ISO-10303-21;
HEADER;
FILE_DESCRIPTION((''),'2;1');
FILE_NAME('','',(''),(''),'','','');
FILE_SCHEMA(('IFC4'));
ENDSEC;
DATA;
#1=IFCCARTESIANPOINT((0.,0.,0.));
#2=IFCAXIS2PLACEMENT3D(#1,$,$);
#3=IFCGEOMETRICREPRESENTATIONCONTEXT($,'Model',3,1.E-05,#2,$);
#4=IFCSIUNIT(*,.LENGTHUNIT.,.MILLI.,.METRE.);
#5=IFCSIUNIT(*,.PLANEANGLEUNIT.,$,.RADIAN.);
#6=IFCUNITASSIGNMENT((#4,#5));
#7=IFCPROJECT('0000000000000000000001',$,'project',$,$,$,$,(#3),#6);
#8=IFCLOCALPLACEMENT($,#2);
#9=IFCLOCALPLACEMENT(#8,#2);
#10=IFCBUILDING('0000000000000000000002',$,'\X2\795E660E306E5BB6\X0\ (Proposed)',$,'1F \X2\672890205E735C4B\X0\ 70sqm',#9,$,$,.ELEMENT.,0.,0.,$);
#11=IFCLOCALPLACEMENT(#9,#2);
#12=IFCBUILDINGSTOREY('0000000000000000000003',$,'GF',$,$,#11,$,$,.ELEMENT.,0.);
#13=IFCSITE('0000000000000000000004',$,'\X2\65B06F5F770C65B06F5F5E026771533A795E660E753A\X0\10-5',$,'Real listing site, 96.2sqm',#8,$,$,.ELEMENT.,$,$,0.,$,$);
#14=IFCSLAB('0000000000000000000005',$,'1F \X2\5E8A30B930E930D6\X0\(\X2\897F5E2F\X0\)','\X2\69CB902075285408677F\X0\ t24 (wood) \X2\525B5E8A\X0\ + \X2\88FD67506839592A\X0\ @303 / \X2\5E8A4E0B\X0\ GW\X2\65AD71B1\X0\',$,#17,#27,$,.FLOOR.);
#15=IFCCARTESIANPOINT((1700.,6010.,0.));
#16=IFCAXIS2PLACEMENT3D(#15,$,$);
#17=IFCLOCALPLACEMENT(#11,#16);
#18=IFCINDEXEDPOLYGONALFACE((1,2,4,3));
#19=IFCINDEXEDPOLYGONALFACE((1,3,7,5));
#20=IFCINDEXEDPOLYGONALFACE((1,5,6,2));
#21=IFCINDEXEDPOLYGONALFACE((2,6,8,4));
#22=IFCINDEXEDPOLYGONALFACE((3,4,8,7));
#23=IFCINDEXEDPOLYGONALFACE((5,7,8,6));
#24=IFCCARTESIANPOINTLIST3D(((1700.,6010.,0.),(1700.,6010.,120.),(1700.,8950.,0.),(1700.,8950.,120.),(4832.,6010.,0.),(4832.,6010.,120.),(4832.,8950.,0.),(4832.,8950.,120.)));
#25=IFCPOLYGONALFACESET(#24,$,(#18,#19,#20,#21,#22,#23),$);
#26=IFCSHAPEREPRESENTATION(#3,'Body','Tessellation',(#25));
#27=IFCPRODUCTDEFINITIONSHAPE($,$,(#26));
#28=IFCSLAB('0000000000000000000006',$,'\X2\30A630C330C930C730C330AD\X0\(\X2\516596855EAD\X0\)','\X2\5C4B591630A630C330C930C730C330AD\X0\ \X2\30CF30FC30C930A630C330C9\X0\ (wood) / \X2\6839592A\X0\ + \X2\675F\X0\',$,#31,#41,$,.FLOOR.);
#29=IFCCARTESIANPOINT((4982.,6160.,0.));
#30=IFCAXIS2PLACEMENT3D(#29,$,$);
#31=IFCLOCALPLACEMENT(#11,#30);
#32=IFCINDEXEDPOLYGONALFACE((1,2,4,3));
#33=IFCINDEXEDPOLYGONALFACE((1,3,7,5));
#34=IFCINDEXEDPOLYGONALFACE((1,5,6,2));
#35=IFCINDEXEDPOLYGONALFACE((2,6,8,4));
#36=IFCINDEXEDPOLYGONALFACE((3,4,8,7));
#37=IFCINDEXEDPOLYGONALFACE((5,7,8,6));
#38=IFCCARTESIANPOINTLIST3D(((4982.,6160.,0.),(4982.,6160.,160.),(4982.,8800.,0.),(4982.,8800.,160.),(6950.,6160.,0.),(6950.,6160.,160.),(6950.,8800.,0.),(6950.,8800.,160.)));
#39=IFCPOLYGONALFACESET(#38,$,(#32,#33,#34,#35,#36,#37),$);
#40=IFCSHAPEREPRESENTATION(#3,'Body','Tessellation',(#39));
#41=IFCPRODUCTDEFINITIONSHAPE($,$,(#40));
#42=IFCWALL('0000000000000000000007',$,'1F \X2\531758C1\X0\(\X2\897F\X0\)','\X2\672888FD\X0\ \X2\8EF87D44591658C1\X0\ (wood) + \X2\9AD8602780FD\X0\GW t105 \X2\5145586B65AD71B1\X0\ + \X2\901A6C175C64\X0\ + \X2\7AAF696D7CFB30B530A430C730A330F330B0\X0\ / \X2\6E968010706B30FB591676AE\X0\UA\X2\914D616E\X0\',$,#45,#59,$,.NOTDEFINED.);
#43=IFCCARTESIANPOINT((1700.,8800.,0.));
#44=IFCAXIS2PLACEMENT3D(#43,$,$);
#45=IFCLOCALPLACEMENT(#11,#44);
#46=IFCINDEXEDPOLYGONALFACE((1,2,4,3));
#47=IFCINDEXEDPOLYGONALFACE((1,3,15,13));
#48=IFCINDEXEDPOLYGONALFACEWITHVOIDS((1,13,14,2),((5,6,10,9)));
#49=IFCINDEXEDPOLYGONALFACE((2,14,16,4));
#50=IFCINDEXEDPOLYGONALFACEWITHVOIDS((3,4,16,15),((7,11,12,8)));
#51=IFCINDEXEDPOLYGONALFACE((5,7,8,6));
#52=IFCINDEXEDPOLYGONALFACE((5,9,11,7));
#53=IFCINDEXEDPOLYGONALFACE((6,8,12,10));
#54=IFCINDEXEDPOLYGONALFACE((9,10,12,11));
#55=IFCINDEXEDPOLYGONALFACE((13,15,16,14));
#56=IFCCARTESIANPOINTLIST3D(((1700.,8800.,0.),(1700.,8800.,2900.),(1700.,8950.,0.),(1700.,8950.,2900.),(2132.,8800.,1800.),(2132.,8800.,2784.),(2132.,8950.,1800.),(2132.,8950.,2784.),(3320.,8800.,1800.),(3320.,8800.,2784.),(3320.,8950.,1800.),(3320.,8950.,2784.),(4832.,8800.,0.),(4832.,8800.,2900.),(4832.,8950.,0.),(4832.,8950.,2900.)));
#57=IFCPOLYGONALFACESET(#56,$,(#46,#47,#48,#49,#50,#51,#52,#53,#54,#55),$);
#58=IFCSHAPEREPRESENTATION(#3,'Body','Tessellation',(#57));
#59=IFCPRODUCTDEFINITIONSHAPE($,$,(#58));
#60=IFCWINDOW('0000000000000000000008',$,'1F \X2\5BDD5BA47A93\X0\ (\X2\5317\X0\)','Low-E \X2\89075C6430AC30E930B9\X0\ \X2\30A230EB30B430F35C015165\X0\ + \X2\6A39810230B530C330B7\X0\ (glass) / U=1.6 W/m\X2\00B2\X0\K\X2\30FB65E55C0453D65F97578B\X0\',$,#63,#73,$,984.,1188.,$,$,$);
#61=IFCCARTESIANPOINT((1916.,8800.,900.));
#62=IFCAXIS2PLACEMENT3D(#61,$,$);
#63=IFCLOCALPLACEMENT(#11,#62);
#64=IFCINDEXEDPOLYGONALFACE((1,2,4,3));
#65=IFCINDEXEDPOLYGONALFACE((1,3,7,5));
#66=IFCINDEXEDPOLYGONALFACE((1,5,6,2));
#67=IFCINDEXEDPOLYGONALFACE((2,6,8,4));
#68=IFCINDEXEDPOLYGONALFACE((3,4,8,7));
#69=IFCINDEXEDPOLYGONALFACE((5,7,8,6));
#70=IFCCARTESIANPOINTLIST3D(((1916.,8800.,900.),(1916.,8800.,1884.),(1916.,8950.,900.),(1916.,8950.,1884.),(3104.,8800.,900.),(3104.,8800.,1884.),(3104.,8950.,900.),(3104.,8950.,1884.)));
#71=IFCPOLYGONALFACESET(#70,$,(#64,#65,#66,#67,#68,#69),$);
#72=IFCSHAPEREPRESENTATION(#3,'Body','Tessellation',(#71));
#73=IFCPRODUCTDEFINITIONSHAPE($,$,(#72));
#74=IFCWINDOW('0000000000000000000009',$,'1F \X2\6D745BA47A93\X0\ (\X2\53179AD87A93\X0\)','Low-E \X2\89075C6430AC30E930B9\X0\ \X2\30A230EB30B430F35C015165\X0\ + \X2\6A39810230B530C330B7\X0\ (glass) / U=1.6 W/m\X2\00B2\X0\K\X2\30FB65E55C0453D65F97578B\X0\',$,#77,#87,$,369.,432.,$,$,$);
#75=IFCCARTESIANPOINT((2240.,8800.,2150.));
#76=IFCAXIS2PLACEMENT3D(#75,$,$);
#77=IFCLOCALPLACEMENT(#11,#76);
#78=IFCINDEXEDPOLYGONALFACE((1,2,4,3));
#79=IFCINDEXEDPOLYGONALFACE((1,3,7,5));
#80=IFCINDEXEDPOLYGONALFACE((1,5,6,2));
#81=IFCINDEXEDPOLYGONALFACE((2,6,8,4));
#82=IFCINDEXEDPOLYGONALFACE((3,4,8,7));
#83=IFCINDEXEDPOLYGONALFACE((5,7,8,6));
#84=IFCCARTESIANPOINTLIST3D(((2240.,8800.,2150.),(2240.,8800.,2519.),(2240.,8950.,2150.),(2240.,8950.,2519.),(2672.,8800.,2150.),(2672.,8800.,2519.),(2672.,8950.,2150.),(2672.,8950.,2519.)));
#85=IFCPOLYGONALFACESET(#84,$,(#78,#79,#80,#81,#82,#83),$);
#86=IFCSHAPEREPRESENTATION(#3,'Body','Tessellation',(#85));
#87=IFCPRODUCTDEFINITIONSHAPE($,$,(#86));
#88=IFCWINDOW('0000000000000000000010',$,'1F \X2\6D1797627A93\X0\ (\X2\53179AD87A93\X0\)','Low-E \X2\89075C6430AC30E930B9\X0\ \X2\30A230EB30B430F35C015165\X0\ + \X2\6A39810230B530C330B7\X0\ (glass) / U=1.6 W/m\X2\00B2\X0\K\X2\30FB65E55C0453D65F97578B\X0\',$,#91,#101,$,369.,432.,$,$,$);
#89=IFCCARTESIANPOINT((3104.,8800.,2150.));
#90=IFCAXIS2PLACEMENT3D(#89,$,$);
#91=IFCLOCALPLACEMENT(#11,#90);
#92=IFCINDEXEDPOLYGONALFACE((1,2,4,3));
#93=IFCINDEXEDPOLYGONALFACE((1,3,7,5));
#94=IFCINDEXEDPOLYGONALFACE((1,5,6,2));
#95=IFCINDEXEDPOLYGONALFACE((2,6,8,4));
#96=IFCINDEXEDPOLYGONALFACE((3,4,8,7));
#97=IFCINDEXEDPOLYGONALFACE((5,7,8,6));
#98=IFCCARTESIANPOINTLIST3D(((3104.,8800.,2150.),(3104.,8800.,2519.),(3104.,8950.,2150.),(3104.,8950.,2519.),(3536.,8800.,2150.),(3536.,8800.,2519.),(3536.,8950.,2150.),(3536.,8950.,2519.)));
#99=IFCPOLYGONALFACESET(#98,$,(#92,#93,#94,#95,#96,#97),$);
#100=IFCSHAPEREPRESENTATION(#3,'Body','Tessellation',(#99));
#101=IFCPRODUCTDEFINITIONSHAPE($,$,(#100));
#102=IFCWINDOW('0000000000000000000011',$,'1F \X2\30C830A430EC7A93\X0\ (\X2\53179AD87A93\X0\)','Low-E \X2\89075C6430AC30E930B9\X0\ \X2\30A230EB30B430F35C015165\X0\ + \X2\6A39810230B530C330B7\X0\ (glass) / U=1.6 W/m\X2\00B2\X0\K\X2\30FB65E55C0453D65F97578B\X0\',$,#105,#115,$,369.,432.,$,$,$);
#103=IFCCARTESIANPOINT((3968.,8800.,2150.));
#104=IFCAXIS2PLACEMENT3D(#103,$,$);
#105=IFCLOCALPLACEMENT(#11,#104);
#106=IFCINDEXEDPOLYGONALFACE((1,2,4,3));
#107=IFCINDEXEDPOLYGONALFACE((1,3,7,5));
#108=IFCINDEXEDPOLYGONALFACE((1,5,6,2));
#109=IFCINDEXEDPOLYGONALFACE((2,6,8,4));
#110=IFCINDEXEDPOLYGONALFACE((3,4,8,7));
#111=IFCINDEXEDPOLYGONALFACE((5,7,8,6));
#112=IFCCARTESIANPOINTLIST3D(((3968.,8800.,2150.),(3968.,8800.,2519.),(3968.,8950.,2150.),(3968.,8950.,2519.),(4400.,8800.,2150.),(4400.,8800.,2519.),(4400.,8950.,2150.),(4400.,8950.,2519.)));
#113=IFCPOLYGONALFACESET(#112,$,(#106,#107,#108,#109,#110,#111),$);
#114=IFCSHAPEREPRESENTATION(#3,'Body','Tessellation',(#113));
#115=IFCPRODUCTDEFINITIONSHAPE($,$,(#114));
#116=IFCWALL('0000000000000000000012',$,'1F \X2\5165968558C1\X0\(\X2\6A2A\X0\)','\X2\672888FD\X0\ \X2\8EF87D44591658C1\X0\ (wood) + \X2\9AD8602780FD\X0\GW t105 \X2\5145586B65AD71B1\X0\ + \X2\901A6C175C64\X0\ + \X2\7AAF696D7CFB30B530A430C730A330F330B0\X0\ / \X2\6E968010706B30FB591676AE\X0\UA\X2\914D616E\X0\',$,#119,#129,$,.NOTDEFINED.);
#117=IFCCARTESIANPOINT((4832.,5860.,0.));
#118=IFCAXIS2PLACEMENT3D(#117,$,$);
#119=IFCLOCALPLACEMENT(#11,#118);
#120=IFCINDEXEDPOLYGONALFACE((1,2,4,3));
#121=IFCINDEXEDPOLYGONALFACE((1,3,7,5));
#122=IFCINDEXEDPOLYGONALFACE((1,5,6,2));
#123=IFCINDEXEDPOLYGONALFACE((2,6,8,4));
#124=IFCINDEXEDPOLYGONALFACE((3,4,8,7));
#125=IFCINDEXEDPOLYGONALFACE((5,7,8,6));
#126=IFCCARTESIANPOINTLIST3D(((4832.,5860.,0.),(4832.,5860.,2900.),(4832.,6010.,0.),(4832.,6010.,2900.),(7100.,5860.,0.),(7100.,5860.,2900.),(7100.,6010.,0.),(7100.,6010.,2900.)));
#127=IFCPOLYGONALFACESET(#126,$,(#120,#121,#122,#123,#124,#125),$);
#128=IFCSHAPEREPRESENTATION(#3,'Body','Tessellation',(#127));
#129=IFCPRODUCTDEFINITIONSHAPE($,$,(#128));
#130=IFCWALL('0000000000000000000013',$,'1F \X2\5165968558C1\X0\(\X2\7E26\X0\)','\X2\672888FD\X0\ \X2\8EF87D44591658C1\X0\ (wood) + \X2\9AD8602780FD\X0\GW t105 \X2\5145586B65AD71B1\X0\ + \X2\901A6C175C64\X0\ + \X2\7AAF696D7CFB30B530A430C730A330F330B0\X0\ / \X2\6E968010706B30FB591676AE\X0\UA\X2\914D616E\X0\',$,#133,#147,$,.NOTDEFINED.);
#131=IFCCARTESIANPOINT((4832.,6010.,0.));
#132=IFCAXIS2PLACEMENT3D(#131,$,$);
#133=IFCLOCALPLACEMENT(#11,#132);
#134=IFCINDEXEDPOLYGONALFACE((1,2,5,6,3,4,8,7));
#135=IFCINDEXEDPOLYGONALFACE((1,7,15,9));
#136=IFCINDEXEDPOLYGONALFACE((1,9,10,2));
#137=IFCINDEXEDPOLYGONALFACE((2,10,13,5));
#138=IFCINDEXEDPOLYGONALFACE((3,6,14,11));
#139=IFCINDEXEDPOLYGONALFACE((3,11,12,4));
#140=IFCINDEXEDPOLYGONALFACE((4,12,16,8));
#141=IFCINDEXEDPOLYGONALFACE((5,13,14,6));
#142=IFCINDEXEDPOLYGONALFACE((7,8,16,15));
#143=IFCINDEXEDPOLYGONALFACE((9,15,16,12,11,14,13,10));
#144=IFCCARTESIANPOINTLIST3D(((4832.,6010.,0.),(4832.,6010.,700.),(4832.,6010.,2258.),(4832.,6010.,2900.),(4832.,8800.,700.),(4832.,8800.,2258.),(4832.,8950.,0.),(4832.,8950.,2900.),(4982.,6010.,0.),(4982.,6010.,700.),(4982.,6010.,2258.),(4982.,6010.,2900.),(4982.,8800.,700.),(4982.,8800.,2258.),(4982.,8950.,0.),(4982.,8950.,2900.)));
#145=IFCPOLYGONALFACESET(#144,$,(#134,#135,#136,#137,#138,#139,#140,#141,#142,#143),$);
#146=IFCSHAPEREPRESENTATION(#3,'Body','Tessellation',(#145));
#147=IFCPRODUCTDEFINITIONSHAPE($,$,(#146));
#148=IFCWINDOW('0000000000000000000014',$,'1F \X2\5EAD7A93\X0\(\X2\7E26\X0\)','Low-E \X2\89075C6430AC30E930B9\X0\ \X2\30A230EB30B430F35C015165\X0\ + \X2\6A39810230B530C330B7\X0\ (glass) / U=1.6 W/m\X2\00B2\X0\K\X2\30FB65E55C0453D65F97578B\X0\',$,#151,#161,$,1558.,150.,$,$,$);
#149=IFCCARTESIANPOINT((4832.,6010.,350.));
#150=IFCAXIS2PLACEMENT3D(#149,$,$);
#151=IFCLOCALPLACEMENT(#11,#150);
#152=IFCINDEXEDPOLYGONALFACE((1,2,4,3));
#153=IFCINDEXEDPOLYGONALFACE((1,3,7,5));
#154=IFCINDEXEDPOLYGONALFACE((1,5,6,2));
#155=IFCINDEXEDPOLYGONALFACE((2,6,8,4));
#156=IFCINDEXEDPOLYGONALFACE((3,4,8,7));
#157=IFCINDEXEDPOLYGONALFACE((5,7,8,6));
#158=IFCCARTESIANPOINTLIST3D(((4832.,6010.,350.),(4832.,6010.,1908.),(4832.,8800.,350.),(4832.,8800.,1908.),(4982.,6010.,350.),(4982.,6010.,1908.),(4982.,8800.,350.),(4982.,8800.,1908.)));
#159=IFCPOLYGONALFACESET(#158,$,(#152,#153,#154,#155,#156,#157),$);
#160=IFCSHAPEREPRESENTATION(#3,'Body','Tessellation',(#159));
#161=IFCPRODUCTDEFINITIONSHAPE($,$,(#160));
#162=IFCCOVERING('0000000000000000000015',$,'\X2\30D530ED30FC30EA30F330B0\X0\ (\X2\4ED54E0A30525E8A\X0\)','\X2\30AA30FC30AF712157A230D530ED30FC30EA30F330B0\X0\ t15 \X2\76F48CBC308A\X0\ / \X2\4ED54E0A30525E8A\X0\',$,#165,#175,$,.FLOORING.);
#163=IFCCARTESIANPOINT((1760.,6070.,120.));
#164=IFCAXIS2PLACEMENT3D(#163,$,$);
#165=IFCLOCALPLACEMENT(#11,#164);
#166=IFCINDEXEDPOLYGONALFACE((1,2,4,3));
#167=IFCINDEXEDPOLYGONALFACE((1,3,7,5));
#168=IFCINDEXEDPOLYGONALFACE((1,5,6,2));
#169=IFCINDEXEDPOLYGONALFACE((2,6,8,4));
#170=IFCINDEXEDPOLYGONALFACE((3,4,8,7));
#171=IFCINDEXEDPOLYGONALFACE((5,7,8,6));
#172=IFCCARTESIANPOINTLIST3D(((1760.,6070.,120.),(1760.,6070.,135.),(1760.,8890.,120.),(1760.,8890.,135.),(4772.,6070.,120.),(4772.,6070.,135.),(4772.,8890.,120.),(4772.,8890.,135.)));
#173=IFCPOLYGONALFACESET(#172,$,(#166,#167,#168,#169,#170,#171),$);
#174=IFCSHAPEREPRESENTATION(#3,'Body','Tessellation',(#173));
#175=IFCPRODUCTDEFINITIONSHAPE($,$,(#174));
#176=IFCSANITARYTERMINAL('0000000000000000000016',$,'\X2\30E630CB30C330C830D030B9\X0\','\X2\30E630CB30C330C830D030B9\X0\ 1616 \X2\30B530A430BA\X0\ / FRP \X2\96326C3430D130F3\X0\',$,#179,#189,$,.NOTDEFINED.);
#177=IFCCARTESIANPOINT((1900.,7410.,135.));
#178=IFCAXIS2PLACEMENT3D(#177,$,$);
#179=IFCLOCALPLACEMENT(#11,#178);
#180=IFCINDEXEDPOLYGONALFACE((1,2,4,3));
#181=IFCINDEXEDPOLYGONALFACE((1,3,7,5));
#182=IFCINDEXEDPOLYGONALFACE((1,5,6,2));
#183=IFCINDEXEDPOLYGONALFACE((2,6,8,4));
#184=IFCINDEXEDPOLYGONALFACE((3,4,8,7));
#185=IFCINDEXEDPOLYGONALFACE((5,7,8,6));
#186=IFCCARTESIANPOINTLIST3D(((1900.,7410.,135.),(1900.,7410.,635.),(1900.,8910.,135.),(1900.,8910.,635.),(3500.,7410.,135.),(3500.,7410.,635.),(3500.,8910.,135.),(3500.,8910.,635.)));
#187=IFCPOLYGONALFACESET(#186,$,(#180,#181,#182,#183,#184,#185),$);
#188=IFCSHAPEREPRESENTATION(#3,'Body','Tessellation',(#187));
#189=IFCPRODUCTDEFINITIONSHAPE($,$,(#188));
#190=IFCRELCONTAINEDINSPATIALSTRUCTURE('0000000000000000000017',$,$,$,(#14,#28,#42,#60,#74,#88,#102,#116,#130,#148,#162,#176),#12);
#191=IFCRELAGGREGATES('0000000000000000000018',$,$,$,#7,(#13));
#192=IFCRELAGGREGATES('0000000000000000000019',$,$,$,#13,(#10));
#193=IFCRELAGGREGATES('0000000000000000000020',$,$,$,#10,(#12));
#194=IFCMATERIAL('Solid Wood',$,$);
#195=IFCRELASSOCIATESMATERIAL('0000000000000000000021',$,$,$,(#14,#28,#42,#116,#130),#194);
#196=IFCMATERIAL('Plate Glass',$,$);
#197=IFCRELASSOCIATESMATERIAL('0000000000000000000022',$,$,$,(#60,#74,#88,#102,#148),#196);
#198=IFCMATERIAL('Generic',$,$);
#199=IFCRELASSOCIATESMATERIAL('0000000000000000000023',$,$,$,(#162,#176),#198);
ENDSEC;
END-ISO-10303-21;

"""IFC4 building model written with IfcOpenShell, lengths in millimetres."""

from ifc_helpers import new_model, si_unit, frame, frame_2d, origin, place, context, project, spatial, rectangle, extrude, material, element, fill, save


model = new_model("IFC4")

# Units and contexts
model_context = context("Model", 3, precision=1e-05, world=origin())
ifc_project = project(units=[si_unit("LENGTHUNIT", "METRE", prefix="MILLI"), si_unit("PLANEANGLEUNIT", "RADIAN")], contexts=[model_context])

# Site, building, storey
site_placement = place(None, origin())
site = spatial("IfcSite", under=ifc_project, at=site_placement, Name="新潟県新潟市東区神明町10-5", ObjectType="Real listing site, 96.2sqm", CompositionType="ELEMENT", RefElevation=0.0)
building_placement = place(site_placement, origin())
building = spatial("IfcBuilding", under=site, at=building_placement, Name="神明の家 (Proposed)", ObjectType="1F 木造平屋 70sqm", CompositionType="ELEMENT", ElevationOfRefHeight=0.0, ElevationOfTerrain=0.0)
storey_placement = place(building_placement, origin())
storey = spatial("IfcBuildingStorey", under=building, at=storey_placement, Name="GF", CompositionType="ELEMENT", Elevation=0.0)

# Slabs
ifc_material_1 = material(Name="Solid Wood")
slab_1_placement = place(storey_placement, frame((1700.0, 6010.0, 0.0)))
element("IfcSlab", 1, at=slab_1_placement, inside=storey, material=ifc_material_1, Name="1F 床スラブ(西帯)", Description="構造用合板 t24 (wood) 剛床 + 製材根太 @303 / 床下 GW断熱", PredefinedType="FLOOR", context=model_context, shape_type="SweptSolid", body=[
    extrude(rectangle(XDim=3132.0, YDim=2940.0, at=frame_2d((1566.0, 1470.0))), frame((1700.0, 6010.0, 0.0)), (0.0, 0.0, 1.0), 120.0),
])
slab_2_placement = place(storey_placement, frame((4982.0, 6160.0, 0.0)))
element("IfcSlab", 2, at=slab_2_placement, inside=storey, material=ifc_material_1, Name="ウッドデッキ(入隅庭)", Description="屋外ウッドデッキ ハードウッド (wood) / 根太 + 束", PredefinedType="FLOOR", context=model_context, shape_type="SweptSolid", body=[
    extrude(rectangle(XDim=1968.0, YDim=2640.0, at=frame_2d((984.0, 1320.0))), frame((4982.0, 6160.0, 0.0)), (0.0, 0.0, 1.0), 160.0),
])

# Wall, openings, windows
wall_1_placement = place(storey_placement, frame((1700.0, 8800.0, 0.0)))
wall_1 = element("IfcWall", 3, at=wall_1_placement, inside=storey, material=ifc_material_1, Name="1F 北壁(西)", Description="木製 軸組外壁 (wood) + 高性能GW t105 充填断熱 + 通気層 + 窯業系サイディング / 準耐火・外皮UA配慮", PredefinedType="NOTDEFINED", context=model_context, shape_type="SweptSolid", body=[
    extrude(rectangle(XDim=3132.0, YDim=150.0, at=frame_2d((1566.0, 75.0))), frame((1700.0, 8800.0, 0.0)), (0.0, 0.0, 1.0), 2900.0),
])
opening_1_placement = place(storey_placement, frame((1916.0, 8800.0, 900.0)))
opening_1 = element("IfcOpeningElement", 4, at=opening_1_placement, cuts=wall_1, PredefinedType="NOTDEFINED", context=model_context, shape_type="SweptSolid", body=[
    extrude(rectangle(XDim=1188.0, YDim=150.0, at=frame_2d((594.0, 75.0))), frame((1916.0, 8800.0, 900.0)), (0.0, 0.0, 1.0), 984.0),
])
opening_2_placement = place(storey_placement, frame((2240.0, 8800.0, 2150.0)))
opening_2 = element("IfcOpeningElement", 5, at=opening_2_placement, cuts=wall_1, PredefinedType="NOTDEFINED", context=model_context, shape_type="SweptSolid", body=[
    extrude(rectangle(XDim=432.0, YDim=150.0, at=frame_2d((216.0, 75.0))), frame((2240.0, 8800.0, 2150.0)), (0.0, 0.0, 1.0), 369.0),
])
opening_3_placement = place(storey_placement, frame((3104.0, 8800.0, 2150.0)))
opening_3 = element("IfcOpeningElement", 6, at=opening_3_placement, cuts=wall_1, PredefinedType="NOTDEFINED", context=model_context, shape_type="SweptSolid", body=[
    extrude(rectangle(XDim=432.0, YDim=150.0, at=frame_2d((216.0, 75.0))), frame((3104.0, 8800.0, 2150.0)), (0.0, 0.0, 1.0), 369.0),
])
opening_4_placement = place(storey_placement, frame((3968.0, 8800.0, 2150.0)))
opening_4 = element("IfcOpeningElement", 7, at=opening_4_placement, cuts=wall_1, PredefinedType="NOTDEFINED", context=model_context, shape_type="SweptSolid", body=[
    extrude(rectangle(XDim=432.0, YDim=150.0, at=frame_2d((216.0, 75.0))), frame((3968.0, 8800.0, 2150.0)), (0.0, 0.0, 1.0), 369.0),
])
ifc_material_2 = material(Name="Plate Glass")
window_1_placement = place(storey_placement, frame((1916.0, 8800.0, 900.0)))
window_1 = element("IfcWindow", 8, at=window_1_placement, inside=storey, material=ifc_material_2, Name="1F 寝室窓 (北)", Description="Low-E 複層ガラス アルゴン封入 + 樹脂サッシ (glass) / U=1.6 W/m²K・日射取得型", OverallHeight=984.0, OverallWidth=1188.0, context=model_context, shape_type="SweptSolid", body=[
    extrude(rectangle(XDim=1188.0, YDim=150.0, at=frame_2d((594.0, 75.0))), frame((1916.0, 8800.0, 900.0)), (0.0, 0.0, 1.0), 984.0),
])
fill(opening_1, window_1)
window_2_placement = place(storey_placement, frame((2240.0, 8800.0, 2150.0)))
window_2 = element("IfcWindow", 9, at=window_2_placement, inside=storey, material=ifc_material_2, Name="1F 浴室窓 (北高窓)", Description="Low-E 複層ガラス アルゴン封入 + 樹脂サッシ (glass) / U=1.6 W/m²K・日射取得型", OverallHeight=369.0, OverallWidth=432.0, context=model_context, shape_type="SweptSolid", body=[
    extrude(rectangle(XDim=432.0, YDim=150.0, at=frame_2d((216.0, 75.0))), frame((2240.0, 8800.0, 2150.0)), (0.0, 0.0, 1.0), 369.0),
])
fill(opening_2, window_2)
window_3_placement = place(storey_placement, frame((3104.0, 8800.0, 2150.0)))
window_3 = element("IfcWindow", 10, at=window_3_placement, inside=storey, material=ifc_material_2, Name="1F 洗面窓 (北高窓)", Description="Low-E 複層ガラス アルゴン封入 + 樹脂サッシ (glass) / U=1.6 W/m²K・日射取得型", OverallHeight=369.0, OverallWidth=432.0, context=model_context, shape_type="SweptSolid", body=[
    extrude(rectangle(XDim=432.0, YDim=150.0, at=frame_2d((216.0, 75.0))), frame((3104.0, 8800.0, 2150.0)), (0.0, 0.0, 1.0), 369.0),
])
fill(opening_3, window_3)
window_4_placement = place(storey_placement, frame((3968.0, 8800.0, 2150.0)))
window_4 = element("IfcWindow", 11, at=window_4_placement, inside=storey, material=ifc_material_2, Name="1F トイレ窓 (北高窓)", Description="Low-E 複層ガラス アルゴン封入 + 樹脂サッシ (glass) / U=1.6 W/m²K・日射取得型", OverallHeight=369.0, OverallWidth=432.0, context=model_context, shape_type="SweptSolid", body=[
    extrude(rectangle(XDim=432.0, YDim=150.0, at=frame_2d((216.0, 75.0))), frame((3968.0, 8800.0, 2150.0)), (0.0, 0.0, 1.0), 369.0),
])
fill(opening_4, window_4)

# Wall
wall_2_placement = place(storey_placement, frame((4832.0, 5860.0, 0.0)))
element("IfcWall", 12, at=wall_2_placement, inside=storey, material=ifc_material_1, Name="1F 入隅壁(横)", Description="木製 軸組外壁 (wood) + 高性能GW t105 充填断熱 + 通気層 + 窯業系サイディング / 準耐火・外皮UA配慮", PredefinedType="NOTDEFINED", context=model_context, shape_type="SweptSolid", body=[
    extrude(rectangle(XDim=2268.0, YDim=150.0, at=frame_2d((1134.0, 75.0))), frame((4832.0, 5860.0, 0.0)), (0.0, 0.0, 1.0), 2900.0),
])

# Wall, opening, window
wall_3_placement = place(storey_placement, frame((4832.0, 6010.0, 0.0)))
wall_3 = element("IfcWall", 13, at=wall_3_placement, inside=storey, material=ifc_material_1, Name="1F 入隅壁(縦)", Description="木製 軸組外壁 (wood) + 高性能GW t105 充填断熱 + 通気層 + 窯業系サイディング / 準耐火・外皮UA配慮", PredefinedType="NOTDEFINED", context=model_context, shape_type="SweptSolid", body=[
    extrude(rectangle(XDim=150.0, YDim=2940.0, at=frame_2d((75.0, 1470.0))), frame((4832.0, 6010.0, 0.0)), (0.0, 0.0, 1.0), 2900.0),
])
opening_5_placement = place(storey_placement, frame((4832.0, 6010.0, 350.0)))
opening_5 = element("IfcOpeningElement", 14, at=opening_5_placement, cuts=wall_3, PredefinedType="NOTDEFINED", context=model_context, shape_type="SweptSolid", body=[
    extrude(rectangle(XDim=150.0, YDim=2790.0, at=frame_2d((75.0, 1395.0))), frame((4832.0, 6010.0, 350.0)), (0.0, 0.0, 1.0), 1558.0),
])
window_5_placement = place(storey_placement, frame((4832.0, 6010.0, 350.0)))
window_5 = element("IfcWindow", 15, at=window_5_placement, inside=storey, material=ifc_material_2, Name="1F 庭窓(縦)", Description="Low-E 複層ガラス アルゴン封入 + 樹脂サッシ (glass) / U=1.6 W/m²K・日射取得型", OverallHeight=1558.0, OverallWidth=150.0, context=model_context, shape_type="SweptSolid", body=[
    extrude(rectangle(XDim=150.0, YDim=2790.0, at=frame_2d((75.0, 1395.0))), frame((4832.0, 6010.0, 350.0)), (0.0, 0.0, 1.0), 1558.0),
])
fill(opening_5, window_5)

# Covering
ifc_material_3 = material(Name="Generic")
covering_placement = place(storey_placement, frame((1760.0, 6070.0, 120.0)))
element("IfcCovering", 16, at=covering_placement, inside=storey, material=ifc_material_3, Name="フローリング (仕上げ床)", Description="オーク無垢フローリング t15 直貼り / 仕上げ床", PredefinedType="FLOORING", context=model_context, shape_type="SweptSolid", body=[
    extrude(rectangle(XDim=3012.0, YDim=2820.0, at=frame_2d((1506.0, 1410.0))), frame((1760.0, 6070.0, 120.0)), (0.0, 0.0, 1.0), 15.0),
])

# Sanitary terminal
sanitary_terminal_1_placement = place(storey_placement, frame((1900.0, 7410.0, 135.0)))
element("IfcSanitaryTerminal", 17, at=sanitary_terminal_1_placement, inside=storey, material=ifc_material_3, Name="ユニットバス", Description="ユニットバス 1616 サイズ / FRP 防水パン", PredefinedType="NOTDEFINED", context=model_context, shape_type="SweptSolid", body=[
    extrude(rectangle(XDim=1600.0, YDim=1500.0, at=frame_2d((800.0, 750.0))), frame((1900.0, 7410.0, 135.0)), (0.0, 0.0, 1.0), 500.0),
])

save(model, "model.ifc")
